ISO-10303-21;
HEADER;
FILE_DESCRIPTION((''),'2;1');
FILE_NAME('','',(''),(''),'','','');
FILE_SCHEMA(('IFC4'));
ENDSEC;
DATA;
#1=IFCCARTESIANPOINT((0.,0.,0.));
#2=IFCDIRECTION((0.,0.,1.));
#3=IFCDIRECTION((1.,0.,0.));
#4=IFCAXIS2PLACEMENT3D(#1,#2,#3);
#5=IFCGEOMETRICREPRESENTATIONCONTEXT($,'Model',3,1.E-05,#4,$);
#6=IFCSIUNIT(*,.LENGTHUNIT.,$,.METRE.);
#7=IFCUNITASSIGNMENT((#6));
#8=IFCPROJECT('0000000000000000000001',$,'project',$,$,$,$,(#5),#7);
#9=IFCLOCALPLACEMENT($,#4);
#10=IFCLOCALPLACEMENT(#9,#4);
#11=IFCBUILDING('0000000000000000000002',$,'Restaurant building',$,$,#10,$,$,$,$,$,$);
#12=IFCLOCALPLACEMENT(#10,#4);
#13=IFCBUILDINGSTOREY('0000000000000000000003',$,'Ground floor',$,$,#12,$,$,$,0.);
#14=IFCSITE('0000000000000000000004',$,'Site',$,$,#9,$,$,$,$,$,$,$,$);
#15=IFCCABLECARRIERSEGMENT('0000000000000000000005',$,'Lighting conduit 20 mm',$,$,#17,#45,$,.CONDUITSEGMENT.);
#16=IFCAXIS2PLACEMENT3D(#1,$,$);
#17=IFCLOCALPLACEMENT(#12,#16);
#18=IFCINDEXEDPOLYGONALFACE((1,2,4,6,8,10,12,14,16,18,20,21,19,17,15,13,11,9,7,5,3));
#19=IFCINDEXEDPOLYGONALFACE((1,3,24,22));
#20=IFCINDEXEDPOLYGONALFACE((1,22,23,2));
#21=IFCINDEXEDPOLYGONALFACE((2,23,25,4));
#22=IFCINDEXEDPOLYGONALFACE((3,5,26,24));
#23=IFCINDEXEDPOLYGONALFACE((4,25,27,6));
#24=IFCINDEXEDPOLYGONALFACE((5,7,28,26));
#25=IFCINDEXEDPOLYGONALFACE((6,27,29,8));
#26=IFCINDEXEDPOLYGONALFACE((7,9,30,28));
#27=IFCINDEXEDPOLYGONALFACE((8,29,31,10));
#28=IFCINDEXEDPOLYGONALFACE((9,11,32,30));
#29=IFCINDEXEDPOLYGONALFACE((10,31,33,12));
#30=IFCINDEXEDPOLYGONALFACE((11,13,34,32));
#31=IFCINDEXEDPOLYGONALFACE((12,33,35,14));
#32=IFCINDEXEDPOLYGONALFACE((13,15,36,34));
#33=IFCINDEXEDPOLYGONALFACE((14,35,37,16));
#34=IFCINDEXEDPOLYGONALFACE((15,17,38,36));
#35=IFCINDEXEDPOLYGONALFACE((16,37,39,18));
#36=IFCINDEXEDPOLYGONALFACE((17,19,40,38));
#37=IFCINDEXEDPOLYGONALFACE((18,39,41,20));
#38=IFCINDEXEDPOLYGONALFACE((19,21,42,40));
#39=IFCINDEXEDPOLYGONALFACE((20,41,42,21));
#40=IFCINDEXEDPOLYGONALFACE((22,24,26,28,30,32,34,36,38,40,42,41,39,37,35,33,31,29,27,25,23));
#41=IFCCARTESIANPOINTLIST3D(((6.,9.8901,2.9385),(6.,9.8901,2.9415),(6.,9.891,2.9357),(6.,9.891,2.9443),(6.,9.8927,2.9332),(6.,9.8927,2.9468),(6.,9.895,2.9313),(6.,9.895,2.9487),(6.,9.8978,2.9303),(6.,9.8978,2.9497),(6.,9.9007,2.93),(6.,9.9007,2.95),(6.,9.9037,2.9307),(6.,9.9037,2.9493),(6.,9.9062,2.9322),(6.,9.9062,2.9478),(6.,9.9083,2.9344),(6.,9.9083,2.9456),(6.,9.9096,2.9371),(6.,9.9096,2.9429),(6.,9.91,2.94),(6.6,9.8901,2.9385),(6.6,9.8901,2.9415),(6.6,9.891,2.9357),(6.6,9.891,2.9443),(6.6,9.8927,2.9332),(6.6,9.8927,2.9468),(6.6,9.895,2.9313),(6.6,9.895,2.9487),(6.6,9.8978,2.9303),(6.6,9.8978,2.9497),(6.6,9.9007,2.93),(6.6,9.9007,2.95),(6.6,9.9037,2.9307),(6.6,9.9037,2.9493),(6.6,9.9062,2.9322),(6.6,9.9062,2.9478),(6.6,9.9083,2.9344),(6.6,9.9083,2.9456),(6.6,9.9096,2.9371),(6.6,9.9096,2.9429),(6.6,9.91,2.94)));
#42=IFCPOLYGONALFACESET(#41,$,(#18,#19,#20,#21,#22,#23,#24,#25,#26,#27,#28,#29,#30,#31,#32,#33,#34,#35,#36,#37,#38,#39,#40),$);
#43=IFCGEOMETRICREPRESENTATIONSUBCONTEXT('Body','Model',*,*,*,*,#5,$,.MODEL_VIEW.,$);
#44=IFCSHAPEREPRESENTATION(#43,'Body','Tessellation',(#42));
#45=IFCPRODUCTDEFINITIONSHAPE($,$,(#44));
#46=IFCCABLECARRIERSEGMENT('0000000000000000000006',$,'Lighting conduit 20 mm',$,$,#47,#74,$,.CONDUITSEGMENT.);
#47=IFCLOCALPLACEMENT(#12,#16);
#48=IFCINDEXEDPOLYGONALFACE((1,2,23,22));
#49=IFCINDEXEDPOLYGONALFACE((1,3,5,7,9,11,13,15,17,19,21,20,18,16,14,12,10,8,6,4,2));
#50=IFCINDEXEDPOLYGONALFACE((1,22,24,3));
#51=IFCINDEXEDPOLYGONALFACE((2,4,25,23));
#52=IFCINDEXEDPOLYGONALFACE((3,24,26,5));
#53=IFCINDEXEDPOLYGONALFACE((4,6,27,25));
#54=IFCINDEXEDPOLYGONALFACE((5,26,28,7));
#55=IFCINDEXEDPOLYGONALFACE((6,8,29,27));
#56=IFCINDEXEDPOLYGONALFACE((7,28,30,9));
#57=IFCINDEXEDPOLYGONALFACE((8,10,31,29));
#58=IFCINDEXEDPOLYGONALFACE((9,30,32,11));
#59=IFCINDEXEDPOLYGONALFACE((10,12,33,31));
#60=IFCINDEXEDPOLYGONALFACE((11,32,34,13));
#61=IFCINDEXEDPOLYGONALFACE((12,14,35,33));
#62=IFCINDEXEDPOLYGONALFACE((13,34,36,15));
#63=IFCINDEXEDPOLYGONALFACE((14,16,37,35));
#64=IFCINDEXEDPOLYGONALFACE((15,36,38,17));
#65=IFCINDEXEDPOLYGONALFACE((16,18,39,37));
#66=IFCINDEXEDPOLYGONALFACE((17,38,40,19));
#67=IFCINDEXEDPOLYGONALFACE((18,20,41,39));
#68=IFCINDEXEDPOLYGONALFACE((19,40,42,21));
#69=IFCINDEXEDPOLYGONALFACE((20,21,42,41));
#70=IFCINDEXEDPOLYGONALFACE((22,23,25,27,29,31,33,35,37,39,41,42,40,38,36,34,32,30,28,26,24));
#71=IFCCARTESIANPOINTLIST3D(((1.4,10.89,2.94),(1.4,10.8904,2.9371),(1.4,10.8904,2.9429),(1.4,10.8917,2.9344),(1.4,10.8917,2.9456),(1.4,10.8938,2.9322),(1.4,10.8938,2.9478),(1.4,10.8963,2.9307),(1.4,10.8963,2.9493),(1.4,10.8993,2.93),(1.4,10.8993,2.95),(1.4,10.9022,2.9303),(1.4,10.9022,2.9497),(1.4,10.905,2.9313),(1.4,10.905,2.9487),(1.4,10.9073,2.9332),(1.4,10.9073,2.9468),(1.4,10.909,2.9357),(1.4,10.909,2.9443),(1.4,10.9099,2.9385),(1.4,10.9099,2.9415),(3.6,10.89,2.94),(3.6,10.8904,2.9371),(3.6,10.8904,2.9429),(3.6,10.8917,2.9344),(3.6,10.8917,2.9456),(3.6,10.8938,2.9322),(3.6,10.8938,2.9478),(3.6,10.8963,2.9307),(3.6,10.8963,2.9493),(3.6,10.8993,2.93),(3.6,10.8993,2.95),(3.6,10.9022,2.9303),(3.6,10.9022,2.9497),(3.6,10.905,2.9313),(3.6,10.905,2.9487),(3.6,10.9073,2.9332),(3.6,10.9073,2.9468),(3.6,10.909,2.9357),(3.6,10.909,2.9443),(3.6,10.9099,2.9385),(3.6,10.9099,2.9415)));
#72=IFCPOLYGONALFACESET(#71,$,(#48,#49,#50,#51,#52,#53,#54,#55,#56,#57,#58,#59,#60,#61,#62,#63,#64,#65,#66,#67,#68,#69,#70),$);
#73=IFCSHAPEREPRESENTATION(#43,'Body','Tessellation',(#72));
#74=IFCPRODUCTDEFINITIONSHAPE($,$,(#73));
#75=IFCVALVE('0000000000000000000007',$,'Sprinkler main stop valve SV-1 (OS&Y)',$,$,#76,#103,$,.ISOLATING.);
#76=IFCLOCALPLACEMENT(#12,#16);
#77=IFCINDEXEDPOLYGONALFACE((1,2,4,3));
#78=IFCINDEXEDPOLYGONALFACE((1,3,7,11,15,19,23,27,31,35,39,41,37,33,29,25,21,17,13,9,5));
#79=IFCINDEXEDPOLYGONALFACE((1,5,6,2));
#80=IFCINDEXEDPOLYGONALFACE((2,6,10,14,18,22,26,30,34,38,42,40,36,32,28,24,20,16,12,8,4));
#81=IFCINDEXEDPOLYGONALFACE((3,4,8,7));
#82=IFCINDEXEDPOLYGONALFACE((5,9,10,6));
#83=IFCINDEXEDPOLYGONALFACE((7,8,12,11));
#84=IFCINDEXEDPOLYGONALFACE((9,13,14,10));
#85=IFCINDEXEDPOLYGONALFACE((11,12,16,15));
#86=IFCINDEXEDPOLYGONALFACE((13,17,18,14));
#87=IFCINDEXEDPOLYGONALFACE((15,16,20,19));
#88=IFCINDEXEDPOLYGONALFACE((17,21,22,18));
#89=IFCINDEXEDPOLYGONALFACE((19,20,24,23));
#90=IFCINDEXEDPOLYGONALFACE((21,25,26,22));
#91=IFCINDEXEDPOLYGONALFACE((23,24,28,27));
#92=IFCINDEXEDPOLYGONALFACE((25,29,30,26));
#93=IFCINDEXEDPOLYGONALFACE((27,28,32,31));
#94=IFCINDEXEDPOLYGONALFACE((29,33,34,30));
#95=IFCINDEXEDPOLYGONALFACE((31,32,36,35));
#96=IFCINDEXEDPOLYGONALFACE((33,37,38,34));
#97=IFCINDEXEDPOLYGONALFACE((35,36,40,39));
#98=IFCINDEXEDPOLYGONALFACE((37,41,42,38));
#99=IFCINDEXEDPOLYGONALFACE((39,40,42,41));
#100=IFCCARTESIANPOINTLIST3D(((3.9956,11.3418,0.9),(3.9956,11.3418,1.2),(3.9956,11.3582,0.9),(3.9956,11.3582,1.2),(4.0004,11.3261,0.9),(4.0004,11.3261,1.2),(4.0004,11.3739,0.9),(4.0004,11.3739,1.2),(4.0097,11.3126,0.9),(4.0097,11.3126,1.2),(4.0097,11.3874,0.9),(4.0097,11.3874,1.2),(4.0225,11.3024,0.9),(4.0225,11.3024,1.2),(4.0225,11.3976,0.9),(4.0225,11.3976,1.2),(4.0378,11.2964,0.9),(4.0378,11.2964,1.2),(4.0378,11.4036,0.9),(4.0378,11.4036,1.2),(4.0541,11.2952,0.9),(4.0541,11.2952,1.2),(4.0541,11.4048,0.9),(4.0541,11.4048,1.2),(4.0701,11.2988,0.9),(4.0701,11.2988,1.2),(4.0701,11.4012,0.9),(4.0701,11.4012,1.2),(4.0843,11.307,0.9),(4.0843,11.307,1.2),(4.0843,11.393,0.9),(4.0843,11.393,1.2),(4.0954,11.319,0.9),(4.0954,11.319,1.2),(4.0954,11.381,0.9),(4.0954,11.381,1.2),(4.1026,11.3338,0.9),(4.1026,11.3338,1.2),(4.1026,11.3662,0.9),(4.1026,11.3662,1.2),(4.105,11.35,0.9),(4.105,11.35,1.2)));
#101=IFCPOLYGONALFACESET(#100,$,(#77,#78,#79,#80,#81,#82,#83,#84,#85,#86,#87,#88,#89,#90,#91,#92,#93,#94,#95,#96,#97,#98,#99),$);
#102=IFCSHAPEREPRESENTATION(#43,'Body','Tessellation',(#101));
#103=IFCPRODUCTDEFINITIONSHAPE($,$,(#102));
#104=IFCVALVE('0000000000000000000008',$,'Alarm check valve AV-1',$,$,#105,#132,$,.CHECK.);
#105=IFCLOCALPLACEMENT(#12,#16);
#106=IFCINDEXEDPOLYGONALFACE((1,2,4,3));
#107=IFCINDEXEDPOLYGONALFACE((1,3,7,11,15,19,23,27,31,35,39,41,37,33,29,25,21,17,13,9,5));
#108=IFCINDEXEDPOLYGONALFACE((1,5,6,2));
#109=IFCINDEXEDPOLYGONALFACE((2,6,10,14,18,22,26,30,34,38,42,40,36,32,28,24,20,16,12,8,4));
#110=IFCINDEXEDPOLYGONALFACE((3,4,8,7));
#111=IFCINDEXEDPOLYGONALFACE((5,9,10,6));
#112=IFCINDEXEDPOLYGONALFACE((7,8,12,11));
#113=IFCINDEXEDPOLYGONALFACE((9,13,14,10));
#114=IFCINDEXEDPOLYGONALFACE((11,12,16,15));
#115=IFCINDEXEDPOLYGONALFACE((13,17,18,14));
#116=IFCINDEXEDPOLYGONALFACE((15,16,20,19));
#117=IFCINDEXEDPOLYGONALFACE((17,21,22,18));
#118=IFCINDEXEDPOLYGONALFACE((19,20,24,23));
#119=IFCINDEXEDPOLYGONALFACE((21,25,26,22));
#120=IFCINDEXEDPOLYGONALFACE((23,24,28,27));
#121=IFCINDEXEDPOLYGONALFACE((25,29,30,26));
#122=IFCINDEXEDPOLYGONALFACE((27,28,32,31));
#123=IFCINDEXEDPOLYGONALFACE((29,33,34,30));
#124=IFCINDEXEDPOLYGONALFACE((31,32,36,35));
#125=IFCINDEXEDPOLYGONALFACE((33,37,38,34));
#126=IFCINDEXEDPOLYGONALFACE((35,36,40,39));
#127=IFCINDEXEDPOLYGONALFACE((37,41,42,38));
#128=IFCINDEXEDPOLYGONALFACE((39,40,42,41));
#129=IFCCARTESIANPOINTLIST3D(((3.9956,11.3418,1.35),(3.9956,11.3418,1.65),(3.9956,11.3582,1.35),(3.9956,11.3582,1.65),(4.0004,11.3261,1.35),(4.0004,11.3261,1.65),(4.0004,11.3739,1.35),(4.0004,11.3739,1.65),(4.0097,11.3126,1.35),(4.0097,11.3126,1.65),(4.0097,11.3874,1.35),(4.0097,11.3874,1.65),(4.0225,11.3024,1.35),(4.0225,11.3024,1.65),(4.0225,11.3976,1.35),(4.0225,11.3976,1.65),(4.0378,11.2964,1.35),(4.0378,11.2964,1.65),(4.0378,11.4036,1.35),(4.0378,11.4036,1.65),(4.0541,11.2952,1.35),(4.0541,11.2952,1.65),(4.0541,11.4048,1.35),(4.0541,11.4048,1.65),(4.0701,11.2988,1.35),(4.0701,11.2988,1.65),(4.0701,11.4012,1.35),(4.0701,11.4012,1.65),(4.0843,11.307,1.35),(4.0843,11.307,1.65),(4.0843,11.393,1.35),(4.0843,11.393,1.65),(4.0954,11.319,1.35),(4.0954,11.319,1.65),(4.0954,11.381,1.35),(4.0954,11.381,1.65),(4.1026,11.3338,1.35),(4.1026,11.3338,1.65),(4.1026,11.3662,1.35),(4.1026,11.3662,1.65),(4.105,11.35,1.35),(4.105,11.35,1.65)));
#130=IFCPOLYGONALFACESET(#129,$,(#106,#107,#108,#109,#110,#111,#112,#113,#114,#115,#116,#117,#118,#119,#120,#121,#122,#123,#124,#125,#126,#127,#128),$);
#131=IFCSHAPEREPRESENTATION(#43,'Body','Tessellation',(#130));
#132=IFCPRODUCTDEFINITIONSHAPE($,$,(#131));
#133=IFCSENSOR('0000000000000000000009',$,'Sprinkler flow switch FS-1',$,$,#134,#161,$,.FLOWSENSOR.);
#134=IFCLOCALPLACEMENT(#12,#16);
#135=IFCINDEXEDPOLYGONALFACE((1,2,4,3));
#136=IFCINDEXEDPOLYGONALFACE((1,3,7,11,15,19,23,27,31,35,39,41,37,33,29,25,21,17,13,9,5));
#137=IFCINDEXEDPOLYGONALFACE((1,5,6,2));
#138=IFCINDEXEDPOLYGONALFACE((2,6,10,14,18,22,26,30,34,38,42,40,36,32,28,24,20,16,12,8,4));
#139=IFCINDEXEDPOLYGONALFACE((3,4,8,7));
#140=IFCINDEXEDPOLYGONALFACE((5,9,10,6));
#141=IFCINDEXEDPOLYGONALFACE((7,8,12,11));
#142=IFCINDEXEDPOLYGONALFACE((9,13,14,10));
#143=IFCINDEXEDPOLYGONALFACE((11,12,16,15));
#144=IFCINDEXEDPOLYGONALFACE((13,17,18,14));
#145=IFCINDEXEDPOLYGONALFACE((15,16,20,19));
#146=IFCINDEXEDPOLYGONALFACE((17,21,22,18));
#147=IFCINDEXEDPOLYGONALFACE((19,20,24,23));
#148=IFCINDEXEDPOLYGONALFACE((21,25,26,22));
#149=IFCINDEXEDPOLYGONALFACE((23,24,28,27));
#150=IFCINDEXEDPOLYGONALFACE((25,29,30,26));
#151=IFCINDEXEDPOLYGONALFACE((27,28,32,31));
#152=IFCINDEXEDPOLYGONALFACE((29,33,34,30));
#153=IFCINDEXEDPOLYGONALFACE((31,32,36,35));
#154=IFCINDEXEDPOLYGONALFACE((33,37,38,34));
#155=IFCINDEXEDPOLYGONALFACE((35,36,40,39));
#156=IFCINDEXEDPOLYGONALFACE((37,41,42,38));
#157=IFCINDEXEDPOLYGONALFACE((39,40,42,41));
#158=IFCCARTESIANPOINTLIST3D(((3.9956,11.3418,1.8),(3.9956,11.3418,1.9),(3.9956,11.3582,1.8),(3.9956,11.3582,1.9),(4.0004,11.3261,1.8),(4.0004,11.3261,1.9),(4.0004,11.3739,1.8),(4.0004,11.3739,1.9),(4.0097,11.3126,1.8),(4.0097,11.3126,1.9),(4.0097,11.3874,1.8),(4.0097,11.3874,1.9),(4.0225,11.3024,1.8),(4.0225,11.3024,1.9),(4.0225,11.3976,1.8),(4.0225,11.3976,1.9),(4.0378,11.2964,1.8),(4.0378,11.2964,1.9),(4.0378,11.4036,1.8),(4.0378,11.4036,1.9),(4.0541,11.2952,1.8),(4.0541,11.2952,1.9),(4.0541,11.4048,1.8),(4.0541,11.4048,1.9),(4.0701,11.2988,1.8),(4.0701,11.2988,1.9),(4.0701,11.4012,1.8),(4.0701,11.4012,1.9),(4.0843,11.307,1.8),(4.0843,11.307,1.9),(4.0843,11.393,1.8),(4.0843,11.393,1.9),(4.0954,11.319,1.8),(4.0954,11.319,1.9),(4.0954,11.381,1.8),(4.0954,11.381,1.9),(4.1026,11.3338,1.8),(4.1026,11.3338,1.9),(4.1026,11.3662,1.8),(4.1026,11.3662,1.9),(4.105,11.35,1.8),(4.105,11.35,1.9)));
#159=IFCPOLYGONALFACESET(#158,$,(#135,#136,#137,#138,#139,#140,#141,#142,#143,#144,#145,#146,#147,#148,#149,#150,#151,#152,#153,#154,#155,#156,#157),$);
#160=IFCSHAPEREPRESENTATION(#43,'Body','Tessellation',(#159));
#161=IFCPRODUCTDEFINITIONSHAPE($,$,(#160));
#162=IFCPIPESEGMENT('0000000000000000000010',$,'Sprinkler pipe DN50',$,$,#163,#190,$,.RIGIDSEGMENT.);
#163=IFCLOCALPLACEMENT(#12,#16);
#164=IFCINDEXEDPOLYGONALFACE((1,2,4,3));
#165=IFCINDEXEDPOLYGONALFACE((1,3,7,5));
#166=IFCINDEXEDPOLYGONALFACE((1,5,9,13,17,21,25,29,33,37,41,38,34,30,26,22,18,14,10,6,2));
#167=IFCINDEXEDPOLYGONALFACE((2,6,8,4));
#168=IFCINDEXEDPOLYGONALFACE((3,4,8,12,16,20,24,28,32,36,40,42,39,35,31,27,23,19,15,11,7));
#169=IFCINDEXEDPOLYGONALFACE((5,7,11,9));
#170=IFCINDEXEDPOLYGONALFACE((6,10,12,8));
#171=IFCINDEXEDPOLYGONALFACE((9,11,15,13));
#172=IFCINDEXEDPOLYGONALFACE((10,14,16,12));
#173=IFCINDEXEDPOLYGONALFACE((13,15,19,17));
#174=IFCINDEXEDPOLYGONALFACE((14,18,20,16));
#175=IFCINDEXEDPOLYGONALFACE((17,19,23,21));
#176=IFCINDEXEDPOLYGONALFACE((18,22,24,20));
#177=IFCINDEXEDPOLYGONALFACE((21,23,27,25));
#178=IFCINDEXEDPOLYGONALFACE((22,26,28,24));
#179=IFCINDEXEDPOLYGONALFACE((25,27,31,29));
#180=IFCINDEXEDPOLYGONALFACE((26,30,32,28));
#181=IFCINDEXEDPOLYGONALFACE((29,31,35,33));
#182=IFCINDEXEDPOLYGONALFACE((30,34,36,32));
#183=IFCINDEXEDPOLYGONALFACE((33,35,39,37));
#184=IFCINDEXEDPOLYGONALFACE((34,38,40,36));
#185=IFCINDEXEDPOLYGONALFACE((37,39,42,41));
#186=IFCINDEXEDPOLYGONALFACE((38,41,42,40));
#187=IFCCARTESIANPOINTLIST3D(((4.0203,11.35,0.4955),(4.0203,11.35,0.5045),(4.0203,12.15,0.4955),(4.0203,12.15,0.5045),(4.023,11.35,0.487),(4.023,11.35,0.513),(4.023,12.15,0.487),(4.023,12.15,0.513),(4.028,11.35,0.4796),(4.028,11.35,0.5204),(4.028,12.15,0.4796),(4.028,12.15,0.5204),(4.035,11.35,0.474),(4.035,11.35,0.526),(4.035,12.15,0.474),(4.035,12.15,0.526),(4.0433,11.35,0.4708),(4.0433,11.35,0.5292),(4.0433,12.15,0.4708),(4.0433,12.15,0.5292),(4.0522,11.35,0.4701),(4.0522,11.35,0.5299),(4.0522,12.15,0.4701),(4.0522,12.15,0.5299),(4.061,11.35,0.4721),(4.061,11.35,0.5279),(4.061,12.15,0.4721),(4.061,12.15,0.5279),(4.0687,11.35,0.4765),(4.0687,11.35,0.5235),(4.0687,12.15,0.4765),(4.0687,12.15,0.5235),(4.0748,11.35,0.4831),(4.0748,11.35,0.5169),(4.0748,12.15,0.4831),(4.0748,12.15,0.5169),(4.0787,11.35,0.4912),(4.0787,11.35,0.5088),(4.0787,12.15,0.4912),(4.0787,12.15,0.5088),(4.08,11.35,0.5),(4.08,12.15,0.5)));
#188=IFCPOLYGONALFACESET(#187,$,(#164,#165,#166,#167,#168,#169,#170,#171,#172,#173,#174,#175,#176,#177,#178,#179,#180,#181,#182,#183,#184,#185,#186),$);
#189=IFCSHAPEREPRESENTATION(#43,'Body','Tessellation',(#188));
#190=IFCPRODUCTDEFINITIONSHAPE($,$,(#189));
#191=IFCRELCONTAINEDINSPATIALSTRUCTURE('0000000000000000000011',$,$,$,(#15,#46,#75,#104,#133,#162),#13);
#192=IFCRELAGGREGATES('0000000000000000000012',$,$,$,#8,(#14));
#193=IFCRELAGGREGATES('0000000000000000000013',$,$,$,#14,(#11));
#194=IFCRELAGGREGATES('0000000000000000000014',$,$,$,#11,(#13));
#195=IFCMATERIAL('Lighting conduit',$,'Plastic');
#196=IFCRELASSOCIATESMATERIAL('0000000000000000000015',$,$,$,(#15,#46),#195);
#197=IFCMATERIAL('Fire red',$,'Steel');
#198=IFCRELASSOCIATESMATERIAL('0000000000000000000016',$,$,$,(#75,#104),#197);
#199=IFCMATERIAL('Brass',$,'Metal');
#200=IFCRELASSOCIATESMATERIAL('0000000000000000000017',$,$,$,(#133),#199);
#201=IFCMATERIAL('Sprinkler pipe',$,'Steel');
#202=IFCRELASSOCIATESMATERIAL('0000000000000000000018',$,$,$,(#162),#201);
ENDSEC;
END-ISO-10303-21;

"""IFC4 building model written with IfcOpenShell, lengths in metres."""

from ifc_helpers import new_model, si_unit, frame, origin_with_axes, origin_2d, place, context, subcontext, project, spatial, circle, extrude, material, element, save


model = new_model("IFC4")

# Units and contexts
model_context = context("Model", 3, precision=1e-05, world=origin_with_axes())
body_context = subcontext(model_context, "Body", "Model", "MODEL_VIEW")
ifc_project = project(units=[si_unit("LENGTHUNIT", "METRE")], contexts=[model_context])

# Site, building, storey
site_placement = place(None, origin_with_axes())
site = spatial("IfcSite", under=ifc_project, at=site_placement, Name="Site")
building_placement = place(site_placement, origin_with_axes())
building = spatial("IfcBuilding", under=site, at=building_placement, Name="Restaurant building")
storey_placement = place(building_placement, origin_with_axes())
storey = spatial("IfcBuildingStorey", under=building, at=storey_placement, Name="Ground floor", Elevation=0.0)

# Shared definitions
ifc_material_1 = material(Name="Brass", Category="Metal")

# Cable carrier segments
ifc_material_2 = material(Name="Lighting conduit", Category="Plastic")
cable_carrier_segment_1_placement = place(storey_placement, frame((6.0, 9.9, 2.94)))
element("IfcCableCarrierSegment", 1, at=cable_carrier_segment_1_placement, inside=storey, material=ifc_material_2, Name="Lighting conduit 20 mm", PredefinedType="CONDUITSEGMENT", context=body_context, shape_type="SweptSolid", body=[
    extrude(circle(Radius=0.01, at=origin_2d()), frame((0.0, 0.0, 0.0), z_axis=(1.0, 0.0, 0.0), x_axis=(0.0, 1.0, 0.0)), (0.0, 0.0, 1.0), 0.6),
])
cable_carrier_segment_2_placement = place(storey_placement, frame((3.6, 10.9, 2.94)))
element("IfcCableCarrierSegment", 2, at=cable_carrier_segment_2_placement, inside=storey, material=ifc_material_2, Name="Lighting conduit 20 mm", PredefinedType="CONDUITSEGMENT", context=body_context, shape_type="SweptSolid", body=[
    extrude(circle(Radius=0.01, at=origin_2d()), frame((0.0, 0.0, 0.0), z_axis=(-1.0, 0.0, 0.0), x_axis=(0.0, -1.0, 0.0)), (0.0, 0.0, 1.0), 2.2),
])

# Valves
ifc_material_3 = material(Name="Fire red", Category="Steel")
valve_1_placement = place(storey_placement, frame((4.05, 11.35, 0.0)))
element("IfcValve", 3, at=valve_1_placement, inside=storey, material=ifc_material_3, Name="Sprinkler main stop valve SV-1 (OS&Y)", PredefinedType="ISOLATING", context=body_context, shape_type="SweptSolid", body=[
    extrude(circle(Radius=0.055, at=origin_2d()), frame((0.0, 0.0, 0.9)), (0.0, 0.0, 1.0), 0.3),
])
valve_2_placement = place(storey_placement, frame((4.05, 11.35, 0.0)))
element("IfcValve", 4, at=valve_2_placement, inside=storey, material=ifc_material_3, Name="Alarm check valve AV-1", PredefinedType="CHECK", context=body_context, shape_type="SweptSolid", body=[
    extrude(circle(Radius=0.055, at=origin_2d()), frame((0.0, 0.0, 1.35)), (0.0, 0.0, 1.0), 0.3),
])

# Sensor
sensor_placement = place(storey_placement, frame((4.05, 11.35, 0.0)))
element("IfcSensor", 5, at=sensor_placement, inside=storey, material=ifc_material_1, Name="Sprinkler flow switch FS-1", PredefinedType="FLOWSENSOR", context=body_context, shape_type="SweptSolid", body=[
    extrude(circle(Radius=0.055, at=origin_2d()), frame((0.0, 0.0, 1.8)), (0.0, 0.0, 1.0), 0.1),
])

# Pipe segment
ifc_material_4 = material(Name="Sprinkler pipe", Category="Steel")
pipe_segment_1_placement = place(storey_placement, frame((4.05, 12.15, 0.5)))
element("IfcPipeSegment", 6, at=pipe_segment_1_placement, inside=storey, material=ifc_material_4, Name="Sprinkler pipe DN50", PredefinedType="RIGIDSEGMENT", context=body_context, shape_type="SweptSolid", body=[
    extrude(circle(Radius=0.03, at=origin_2d()), frame((0.0, 0.0, 0.0), z_axis=(0.0, -1.0, 0.0), x_axis=(1.0, 0.0, 0.0)), (0.0, 0.0, 1.0), 0.8),
])

save(model, "model.ifc")
